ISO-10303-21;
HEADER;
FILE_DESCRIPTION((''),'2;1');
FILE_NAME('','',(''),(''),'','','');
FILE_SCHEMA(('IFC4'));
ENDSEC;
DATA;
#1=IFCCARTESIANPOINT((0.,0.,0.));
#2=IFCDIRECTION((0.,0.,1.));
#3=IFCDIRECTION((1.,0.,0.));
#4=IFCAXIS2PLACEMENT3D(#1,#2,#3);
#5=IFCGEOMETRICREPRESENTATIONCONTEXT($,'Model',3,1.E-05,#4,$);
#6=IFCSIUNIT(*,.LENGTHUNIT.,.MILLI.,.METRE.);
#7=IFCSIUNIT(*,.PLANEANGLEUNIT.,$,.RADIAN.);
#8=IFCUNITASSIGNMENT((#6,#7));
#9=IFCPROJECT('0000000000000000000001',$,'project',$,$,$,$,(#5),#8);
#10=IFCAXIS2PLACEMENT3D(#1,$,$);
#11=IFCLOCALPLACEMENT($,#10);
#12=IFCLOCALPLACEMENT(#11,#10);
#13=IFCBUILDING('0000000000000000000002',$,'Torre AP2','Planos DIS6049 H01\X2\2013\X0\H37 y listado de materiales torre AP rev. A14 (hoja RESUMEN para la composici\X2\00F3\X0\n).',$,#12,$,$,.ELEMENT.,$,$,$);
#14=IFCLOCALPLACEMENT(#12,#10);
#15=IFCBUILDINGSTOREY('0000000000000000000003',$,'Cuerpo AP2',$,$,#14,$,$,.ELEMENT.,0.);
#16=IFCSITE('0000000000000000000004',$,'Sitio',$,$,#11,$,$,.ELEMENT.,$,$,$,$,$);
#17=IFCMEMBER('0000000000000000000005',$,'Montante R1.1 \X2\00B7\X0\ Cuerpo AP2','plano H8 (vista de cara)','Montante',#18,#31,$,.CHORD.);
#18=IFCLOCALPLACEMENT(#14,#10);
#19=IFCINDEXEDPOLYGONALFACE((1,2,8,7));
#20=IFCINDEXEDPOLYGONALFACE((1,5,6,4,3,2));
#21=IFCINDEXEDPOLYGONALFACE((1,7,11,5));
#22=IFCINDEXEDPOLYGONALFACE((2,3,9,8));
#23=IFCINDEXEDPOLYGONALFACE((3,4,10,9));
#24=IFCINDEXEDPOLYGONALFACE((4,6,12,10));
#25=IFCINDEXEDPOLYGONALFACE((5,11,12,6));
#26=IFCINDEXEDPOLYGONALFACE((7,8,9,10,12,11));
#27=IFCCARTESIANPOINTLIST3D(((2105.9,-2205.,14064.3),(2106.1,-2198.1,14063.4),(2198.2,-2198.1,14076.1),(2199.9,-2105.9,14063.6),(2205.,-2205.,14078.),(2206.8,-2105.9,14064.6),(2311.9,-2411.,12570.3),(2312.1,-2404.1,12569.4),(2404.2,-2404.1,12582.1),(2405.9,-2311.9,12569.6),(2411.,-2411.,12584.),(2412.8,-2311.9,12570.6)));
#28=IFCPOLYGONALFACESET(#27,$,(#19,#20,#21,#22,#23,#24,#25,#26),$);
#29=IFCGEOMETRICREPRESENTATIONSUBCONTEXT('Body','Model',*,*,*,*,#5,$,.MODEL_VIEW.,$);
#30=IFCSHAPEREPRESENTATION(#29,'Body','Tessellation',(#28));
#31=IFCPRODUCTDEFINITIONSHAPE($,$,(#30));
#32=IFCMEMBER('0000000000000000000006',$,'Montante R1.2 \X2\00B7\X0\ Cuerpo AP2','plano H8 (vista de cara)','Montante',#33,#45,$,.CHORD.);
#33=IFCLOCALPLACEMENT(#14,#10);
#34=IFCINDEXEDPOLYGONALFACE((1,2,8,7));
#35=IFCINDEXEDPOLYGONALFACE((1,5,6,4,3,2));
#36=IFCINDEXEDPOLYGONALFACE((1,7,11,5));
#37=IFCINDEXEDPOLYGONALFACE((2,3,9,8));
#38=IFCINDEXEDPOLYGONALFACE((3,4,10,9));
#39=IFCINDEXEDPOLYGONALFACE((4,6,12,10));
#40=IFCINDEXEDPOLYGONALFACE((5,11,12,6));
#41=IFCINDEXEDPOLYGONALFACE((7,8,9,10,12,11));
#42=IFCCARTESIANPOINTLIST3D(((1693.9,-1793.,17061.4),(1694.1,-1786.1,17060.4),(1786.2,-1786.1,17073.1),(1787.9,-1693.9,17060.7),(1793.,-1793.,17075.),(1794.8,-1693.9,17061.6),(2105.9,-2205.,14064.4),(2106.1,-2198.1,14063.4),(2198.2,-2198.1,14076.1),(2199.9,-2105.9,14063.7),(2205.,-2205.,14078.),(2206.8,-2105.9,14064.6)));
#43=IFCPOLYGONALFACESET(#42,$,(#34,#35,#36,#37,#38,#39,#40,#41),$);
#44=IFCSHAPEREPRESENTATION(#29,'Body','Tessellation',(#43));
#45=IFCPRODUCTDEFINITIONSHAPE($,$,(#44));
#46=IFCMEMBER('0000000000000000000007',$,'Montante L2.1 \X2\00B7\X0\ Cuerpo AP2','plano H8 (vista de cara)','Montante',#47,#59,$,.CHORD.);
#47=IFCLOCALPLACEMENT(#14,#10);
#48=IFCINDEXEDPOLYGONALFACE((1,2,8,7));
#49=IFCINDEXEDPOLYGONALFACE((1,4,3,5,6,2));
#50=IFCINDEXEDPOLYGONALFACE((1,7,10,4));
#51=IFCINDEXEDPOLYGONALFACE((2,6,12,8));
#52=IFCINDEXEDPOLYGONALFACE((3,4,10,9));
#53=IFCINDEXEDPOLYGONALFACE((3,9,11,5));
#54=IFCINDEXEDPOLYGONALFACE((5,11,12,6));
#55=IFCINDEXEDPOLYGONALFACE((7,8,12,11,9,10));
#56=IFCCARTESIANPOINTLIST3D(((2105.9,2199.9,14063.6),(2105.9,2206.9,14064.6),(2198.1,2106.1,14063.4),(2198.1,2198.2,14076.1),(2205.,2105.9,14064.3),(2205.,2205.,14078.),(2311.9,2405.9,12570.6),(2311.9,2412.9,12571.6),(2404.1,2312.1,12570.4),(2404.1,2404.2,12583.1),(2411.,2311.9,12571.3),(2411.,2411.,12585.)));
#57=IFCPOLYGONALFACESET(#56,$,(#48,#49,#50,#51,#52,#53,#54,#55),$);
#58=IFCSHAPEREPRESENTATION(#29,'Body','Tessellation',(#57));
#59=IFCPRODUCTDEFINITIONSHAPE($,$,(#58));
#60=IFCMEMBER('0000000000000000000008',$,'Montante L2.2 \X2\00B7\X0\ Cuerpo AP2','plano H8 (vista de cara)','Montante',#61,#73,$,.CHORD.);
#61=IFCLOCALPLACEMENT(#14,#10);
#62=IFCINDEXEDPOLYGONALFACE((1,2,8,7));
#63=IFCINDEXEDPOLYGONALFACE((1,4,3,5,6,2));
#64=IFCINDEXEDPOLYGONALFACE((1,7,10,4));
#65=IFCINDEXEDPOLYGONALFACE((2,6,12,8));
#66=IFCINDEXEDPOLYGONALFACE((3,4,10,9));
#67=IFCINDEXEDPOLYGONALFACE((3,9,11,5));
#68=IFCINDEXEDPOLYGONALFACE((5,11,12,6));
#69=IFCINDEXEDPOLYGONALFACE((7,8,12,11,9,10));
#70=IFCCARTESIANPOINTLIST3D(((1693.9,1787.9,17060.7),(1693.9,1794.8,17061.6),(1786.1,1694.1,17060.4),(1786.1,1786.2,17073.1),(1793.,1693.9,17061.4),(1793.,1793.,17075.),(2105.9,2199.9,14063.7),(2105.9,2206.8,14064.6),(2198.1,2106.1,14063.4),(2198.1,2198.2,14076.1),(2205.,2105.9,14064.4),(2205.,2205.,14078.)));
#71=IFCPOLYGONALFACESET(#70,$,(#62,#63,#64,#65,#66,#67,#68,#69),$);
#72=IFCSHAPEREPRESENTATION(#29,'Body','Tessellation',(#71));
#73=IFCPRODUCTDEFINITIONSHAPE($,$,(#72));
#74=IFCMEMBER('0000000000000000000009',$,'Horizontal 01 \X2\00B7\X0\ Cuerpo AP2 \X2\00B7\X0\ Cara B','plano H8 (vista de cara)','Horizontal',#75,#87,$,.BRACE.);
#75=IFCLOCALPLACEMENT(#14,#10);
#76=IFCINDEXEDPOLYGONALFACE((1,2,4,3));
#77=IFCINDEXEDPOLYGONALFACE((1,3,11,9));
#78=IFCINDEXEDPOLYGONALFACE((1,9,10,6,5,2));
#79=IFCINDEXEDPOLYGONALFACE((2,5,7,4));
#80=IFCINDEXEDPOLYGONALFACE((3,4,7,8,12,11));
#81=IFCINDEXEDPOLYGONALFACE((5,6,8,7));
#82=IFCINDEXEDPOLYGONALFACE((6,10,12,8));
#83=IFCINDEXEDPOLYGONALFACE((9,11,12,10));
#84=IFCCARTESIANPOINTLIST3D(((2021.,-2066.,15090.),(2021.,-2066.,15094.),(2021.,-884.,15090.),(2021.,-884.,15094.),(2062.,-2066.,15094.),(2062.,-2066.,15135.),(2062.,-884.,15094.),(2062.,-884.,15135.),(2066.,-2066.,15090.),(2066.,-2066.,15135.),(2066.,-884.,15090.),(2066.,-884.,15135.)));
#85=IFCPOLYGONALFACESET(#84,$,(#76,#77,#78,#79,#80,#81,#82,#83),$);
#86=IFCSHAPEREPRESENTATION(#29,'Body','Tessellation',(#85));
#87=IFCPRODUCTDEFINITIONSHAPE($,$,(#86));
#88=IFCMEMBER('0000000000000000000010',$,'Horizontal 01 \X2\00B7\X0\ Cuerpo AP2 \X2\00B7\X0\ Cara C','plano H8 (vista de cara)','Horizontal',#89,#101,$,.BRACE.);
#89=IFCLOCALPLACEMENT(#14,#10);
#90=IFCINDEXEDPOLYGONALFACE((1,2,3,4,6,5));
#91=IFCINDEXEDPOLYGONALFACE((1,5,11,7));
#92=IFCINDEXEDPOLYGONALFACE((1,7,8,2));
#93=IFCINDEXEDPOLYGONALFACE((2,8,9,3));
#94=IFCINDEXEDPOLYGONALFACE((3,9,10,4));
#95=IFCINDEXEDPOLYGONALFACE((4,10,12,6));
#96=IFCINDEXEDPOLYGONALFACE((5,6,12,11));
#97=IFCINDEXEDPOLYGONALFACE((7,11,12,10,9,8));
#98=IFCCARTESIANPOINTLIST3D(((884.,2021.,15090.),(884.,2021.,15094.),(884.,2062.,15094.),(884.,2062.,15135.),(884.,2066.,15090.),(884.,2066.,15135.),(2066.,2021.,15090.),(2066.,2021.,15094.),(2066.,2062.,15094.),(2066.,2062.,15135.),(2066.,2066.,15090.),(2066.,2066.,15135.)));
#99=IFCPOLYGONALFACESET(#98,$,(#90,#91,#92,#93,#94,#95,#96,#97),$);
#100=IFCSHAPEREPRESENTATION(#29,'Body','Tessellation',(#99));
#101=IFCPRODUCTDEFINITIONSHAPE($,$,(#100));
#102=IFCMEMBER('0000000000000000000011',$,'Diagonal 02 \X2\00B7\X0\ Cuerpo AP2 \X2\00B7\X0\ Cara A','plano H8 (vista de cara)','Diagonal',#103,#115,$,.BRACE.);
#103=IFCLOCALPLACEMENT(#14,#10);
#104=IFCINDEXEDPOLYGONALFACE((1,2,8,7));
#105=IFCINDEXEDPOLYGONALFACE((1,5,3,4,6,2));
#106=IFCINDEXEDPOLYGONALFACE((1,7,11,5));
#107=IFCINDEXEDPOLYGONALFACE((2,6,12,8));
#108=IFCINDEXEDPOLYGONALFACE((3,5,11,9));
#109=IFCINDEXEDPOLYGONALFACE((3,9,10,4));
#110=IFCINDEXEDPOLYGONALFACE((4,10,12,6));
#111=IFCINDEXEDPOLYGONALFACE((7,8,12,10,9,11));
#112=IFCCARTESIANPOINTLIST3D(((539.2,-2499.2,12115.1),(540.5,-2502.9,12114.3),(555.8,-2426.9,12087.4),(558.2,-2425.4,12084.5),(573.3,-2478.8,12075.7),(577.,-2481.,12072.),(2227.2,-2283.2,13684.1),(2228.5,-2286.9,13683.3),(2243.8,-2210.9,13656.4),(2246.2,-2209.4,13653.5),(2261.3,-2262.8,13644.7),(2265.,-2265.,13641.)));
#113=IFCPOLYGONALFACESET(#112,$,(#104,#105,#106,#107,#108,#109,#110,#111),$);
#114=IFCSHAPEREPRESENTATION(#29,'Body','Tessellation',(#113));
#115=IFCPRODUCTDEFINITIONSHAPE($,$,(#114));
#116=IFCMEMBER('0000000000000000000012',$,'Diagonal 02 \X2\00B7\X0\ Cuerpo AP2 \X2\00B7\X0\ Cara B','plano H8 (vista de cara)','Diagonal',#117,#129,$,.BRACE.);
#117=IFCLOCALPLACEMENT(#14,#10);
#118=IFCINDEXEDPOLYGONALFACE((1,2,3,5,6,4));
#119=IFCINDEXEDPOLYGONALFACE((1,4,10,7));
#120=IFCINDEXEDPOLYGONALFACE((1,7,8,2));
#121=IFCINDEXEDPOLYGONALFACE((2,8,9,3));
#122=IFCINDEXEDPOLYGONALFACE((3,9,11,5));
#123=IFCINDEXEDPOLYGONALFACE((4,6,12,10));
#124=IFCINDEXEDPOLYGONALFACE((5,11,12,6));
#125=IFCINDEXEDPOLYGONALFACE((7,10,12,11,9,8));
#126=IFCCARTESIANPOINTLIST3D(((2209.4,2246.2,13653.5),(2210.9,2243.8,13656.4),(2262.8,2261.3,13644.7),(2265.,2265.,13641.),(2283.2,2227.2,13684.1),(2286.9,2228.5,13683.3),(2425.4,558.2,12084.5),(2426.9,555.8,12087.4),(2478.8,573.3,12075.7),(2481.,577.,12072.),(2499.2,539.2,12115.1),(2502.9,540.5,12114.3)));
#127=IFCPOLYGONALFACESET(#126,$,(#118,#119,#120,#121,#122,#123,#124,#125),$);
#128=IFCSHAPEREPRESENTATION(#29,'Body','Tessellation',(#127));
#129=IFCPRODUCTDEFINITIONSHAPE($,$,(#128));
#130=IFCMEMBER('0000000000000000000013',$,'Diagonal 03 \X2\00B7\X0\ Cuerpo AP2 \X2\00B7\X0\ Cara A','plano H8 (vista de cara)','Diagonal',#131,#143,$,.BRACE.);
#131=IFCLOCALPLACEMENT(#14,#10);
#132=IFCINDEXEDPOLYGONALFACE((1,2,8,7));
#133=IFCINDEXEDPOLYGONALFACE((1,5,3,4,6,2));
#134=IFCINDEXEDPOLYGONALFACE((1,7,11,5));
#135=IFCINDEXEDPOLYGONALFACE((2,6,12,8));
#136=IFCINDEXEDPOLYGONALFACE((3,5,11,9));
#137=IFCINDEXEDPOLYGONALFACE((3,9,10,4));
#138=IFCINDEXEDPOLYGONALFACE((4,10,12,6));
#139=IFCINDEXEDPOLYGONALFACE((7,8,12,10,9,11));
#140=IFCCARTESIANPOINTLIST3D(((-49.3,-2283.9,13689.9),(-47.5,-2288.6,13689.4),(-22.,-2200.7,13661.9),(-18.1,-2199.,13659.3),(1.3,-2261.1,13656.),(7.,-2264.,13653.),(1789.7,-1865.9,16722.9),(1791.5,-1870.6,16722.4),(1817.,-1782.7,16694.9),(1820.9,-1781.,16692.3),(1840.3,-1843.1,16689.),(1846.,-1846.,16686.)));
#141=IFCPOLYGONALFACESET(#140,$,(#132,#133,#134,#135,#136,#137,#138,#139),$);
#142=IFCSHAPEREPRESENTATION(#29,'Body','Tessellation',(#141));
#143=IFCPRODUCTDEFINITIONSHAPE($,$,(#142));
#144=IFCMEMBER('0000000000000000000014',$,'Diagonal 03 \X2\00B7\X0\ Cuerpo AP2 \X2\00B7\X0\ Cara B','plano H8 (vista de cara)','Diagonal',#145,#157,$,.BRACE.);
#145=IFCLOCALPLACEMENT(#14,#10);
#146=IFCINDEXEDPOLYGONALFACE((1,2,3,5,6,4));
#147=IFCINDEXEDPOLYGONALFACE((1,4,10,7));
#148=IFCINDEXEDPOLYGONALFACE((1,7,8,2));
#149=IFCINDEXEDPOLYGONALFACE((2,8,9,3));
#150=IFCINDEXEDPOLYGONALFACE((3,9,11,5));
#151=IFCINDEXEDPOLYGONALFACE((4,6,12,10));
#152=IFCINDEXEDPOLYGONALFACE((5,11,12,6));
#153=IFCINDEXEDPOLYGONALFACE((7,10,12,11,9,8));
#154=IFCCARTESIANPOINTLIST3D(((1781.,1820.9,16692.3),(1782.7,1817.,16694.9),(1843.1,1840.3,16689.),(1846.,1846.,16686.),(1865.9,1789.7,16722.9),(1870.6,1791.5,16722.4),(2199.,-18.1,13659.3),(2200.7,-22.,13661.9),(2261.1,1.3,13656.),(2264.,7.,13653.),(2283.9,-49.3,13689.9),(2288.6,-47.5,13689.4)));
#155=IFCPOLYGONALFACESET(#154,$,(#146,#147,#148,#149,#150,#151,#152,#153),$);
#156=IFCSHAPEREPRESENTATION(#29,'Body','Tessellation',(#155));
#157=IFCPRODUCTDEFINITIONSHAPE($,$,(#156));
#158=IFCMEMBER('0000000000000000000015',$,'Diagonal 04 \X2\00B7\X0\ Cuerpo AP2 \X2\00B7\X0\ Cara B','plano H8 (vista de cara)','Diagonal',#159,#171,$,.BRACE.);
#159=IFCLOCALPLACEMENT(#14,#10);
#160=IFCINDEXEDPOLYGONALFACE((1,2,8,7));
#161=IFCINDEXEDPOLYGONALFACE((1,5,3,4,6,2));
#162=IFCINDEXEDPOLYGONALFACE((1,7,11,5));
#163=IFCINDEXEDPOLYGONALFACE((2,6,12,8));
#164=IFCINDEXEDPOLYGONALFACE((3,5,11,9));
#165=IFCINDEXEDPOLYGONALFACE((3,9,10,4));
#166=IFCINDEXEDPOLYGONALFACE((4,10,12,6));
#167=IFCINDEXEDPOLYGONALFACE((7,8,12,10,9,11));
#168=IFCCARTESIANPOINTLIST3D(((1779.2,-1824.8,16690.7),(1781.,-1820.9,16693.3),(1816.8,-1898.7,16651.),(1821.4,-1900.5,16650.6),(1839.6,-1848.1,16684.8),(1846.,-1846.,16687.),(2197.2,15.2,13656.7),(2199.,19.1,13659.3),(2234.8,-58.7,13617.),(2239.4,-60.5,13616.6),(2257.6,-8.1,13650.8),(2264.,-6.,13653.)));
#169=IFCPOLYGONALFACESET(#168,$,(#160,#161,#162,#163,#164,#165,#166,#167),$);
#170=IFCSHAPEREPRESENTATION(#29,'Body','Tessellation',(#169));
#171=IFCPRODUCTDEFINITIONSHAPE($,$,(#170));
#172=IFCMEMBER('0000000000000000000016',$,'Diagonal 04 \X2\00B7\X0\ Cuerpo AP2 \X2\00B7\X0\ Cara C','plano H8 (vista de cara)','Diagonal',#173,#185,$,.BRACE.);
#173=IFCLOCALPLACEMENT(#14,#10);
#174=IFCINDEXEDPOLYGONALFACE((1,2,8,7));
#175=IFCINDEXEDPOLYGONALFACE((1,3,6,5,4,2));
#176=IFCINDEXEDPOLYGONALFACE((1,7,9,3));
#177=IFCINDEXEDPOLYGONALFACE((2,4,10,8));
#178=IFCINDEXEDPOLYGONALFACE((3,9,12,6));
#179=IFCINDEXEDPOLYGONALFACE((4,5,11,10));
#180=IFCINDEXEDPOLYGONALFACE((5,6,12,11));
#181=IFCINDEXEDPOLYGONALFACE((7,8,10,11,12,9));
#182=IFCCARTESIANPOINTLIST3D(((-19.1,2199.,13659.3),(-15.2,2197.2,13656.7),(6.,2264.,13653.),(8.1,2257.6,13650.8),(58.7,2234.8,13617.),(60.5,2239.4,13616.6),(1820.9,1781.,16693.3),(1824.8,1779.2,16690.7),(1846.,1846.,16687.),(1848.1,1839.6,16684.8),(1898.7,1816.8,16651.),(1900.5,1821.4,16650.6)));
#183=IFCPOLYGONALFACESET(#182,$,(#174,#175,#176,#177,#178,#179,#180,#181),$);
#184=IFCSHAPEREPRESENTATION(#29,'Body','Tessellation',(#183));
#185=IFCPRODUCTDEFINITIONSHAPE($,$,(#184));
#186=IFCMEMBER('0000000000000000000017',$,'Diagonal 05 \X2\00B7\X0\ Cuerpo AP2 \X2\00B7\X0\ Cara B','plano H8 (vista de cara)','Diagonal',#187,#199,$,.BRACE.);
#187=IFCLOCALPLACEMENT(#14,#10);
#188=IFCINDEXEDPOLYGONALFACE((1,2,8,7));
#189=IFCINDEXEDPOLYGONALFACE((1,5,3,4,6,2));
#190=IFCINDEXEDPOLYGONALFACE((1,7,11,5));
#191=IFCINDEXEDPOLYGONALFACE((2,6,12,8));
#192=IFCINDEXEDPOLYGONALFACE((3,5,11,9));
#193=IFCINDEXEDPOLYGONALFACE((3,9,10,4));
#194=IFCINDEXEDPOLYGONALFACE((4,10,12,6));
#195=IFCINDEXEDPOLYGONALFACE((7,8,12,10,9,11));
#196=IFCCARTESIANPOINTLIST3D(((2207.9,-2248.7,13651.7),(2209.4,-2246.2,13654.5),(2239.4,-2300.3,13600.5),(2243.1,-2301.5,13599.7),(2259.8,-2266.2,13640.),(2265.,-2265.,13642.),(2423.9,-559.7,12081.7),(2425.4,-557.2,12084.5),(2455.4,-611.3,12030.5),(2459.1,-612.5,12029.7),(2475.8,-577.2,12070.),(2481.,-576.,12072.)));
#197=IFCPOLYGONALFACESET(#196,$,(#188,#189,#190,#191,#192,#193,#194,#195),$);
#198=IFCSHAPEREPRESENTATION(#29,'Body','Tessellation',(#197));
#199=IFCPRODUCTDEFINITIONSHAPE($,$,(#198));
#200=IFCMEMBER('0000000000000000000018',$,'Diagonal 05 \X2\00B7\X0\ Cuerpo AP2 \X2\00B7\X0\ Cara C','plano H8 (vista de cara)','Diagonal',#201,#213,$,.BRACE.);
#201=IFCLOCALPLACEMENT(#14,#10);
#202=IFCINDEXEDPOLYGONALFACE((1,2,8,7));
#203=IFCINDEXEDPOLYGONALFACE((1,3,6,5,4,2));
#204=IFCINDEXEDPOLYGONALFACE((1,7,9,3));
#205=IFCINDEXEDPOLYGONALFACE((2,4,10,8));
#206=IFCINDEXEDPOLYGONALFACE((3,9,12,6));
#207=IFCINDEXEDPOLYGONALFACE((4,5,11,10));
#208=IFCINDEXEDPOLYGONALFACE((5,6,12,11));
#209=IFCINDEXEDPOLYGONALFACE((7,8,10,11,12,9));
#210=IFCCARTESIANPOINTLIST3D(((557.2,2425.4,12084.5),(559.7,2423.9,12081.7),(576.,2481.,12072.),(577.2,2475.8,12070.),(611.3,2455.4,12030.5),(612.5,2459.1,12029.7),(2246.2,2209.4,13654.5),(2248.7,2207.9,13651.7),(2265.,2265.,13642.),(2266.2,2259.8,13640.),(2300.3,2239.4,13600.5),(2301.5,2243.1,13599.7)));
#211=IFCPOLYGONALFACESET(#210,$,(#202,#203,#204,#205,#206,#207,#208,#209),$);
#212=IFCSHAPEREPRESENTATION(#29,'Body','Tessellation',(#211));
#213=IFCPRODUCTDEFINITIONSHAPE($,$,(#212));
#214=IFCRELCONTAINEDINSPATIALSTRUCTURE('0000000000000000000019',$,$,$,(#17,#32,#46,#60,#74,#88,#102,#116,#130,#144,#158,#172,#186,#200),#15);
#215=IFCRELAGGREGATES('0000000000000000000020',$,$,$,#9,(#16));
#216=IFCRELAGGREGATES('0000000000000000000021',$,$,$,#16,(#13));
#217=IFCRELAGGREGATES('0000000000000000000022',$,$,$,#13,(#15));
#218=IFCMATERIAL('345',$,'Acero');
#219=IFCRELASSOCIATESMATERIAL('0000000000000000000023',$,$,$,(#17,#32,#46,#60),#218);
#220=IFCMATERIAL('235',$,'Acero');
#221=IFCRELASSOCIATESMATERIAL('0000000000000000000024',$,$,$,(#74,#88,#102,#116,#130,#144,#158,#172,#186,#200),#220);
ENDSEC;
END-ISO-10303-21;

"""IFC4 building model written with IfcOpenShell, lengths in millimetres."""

from ifc_helpers import new_model, si_unit, frame, frame_2d, origin, origin_with_axes, place, context, subcontext, project, spatial, l_section, extrude, material, element, save


model = new_model("IFC4")

# Units and contexts
model_context = context("Model", 3, precision=1e-05, world=origin_with_axes())
body_context = subcontext(model_context, "Body", "Model", "MODEL_VIEW")
ifc_project = project(units=[si_unit("LENGTHUNIT", "METRE", prefix="MILLI"), si_unit("PLANEANGLEUNIT", "RADIAN")], contexts=[model_context])

# Site, building, storey
site_placement = place(None, origin())
site = spatial("IfcSite", under=ifc_project, at=site_placement, Name="Sitio", CompositionType="ELEMENT")
building_placement = place(site_placement, origin())
building = spatial("IfcBuilding", under=site, at=building_placement, Name="Torre AP2", Description="Planos DIS6049 H01–H37 y listado de materiales torre AP rev. A14 (hoja RESUMEN para la composición).", CompositionType="ELEMENT")
storey_placement = place(building_placement, origin())
storey = spatial("IfcBuildingStorey", under=building, at=storey_placement, Name="Cuerpo AP2", CompositionType="ELEMENT", Elevation=0.0)

# Members
ifc_material_1 = material(Name="345", Category="Acero")
member_1_placement = place(storey_placement, frame((2411.0, -2411.0, 12584.0), z_axis=(-0.135336, 0.135336, 0.981513), x_axis=(0.018486, 0.9908, -0.134067)))
element("IfcMember", 1, at=member_1_placement, inside=storey, material=ifc_material_1, Name="Montante R1.1 · Cuerpo AP2", Description="plano H8 (vista de cara)", ObjectType="Montante", PredefinedType="CHORD", context=body_context, shape_type="SweptSolid", body=[
    extrude(l_section(Depth=100.0, Width=100.0, Thickness=7.0, at=frame_2d((50.0, 50.0))), None, (0.0, 0.0, 1.0), 1522.1),
])
member_2_placement = place(storey_placement, frame((2205.0, -2205.0, 14078.0), z_axis=(-0.134944, 0.134944, 0.981621), x_axis=(0.018378, 0.990853, -0.133687)))
element("IfcMember", 2, at=member_2_placement, inside=storey, material=ifc_material_1, Name="Montante R1.2 · Cuerpo AP2", Description="plano H8 (vista de cara)", ObjectType="Montante", PredefinedType="CHORD", context=body_context, shape_type="SweptSolid", body=[
    extrude(l_section(Depth=100.0, Width=100.0, Thickness=7.0, at=frame_2d((50.0, 50.0))), None, (0.0, 0.0, 1.0), 3053.1),
])
member_3_placement = place(storey_placement, frame((2411.0, 2411.0, 12585.0), z_axis=(-0.135423, -0.135423, 0.981489), x_axis=(-0.990788, 0.01851, -0.134152)))
element("IfcMember", 3, at=member_3_placement, inside=storey, material=ifc_material_1, Name="Montante L2.1 · Cuerpo AP2", Description="plano H8 (vista de cara)", ObjectType="Montante", PredefinedType="CHORD", context=body_context, shape_type="SweptSolid", body=[
    extrude(l_section(Depth=100.0, Width=100.0, Thickness=7.0, at=frame_2d((50.0, 50.0))), None, (0.0, 0.0, 1.0), 1521.2),
])
member_4_placement = place(storey_placement, frame((2205.0, 2205.0, 14078.0), z_axis=(-0.134944, -0.134944, 0.981621), x_axis=(-0.990853, 0.018378, -0.133687)))
element("IfcMember", 4, at=member_4_placement, inside=storey, material=ifc_material_1, Name="Montante L2.2 · Cuerpo AP2", Description="plano H8 (vista de cara)", ObjectType="Montante", PredefinedType="CHORD", context=body_context, shape_type="SweptSolid", body=[
    extrude(l_section(Depth=100.0, Width=100.0, Thickness=7.0, at=frame_2d((50.0, 50.0))), None, (0.0, 0.0, 1.0), 3053.1),
])
ifc_material_2 = material(Name="235", Category="Acero")
for number, where, z_axis, x_axis, name in (
    (5, (2066.0, -2066.0, 15090.0), (0.0, 1.0, 0.0), (-1.0, 0.0, 0.0), "Horizontal 01 · Cuerpo AP2 · Cara B"),
    (6, (2066.0, 2066.0, 15090.0), (-1.0, 0.0, 0.0), (0.0, -1.0, 0.0), "Horizontal 01 · Cuerpo AP2 · Cara C"),
):
    element("IfcMember", number, at=place(storey_placement, frame(where, z_axis=z_axis, x_axis=x_axis)), inside=storey, material=ifc_material_2, Name=name, Description="plano H8 (vista de cara)", ObjectType="Horizontal", PredefinedType="BRACE", context=body_context, shape_type="SweptSolid", body=[
        extrude(l_section(Depth=45.0, Width=45.0, Thickness=4.0, at=frame_2d((22.5, 22.5))), None, (0.0, 0.0, 1.0), 1182.0),
    ])
for number, where, z_axis, x_axis, name in (
    (7, (577.0, -2481.0, 12072.0), (0.729257, 0.093317, 0.677846), (-0.312796, 0.926549, 0.208964), "Diagonal 02 · Cuerpo AP2 · Cara A"),
    (8, (2481.0, 577.0, 12072.0), (-0.093317, 0.729257, 0.677846), (-0.926549, -0.312796, 0.208964), "Diagonal 02 · Cuerpo AP2 · Cara B"),
):
    element("IfcMember", number, at=place(storey_placement, frame(where, z_axis=z_axis, x_axis=x_axis)), inside=storey, material=ifc_material_2, Name=name, Description="plano H8 (vista de cara)", ObjectType="Diagonal", PredefinedType="BRACE", context=body_context, shape_type="SweptSolid", body=[
        extrude(l_section(Depth=60.0, Width=60.0, Thickness=4.0, at=frame_2d((30.0, 30.0))), None, (0.0, 0.0, 1.0), 2314.7),
    ])
for number, where, z_axis, x_axis, name in (
    (9, (7.0, -2264.0, 13653.0), (0.514907, 0.117037, 0.849219), (-0.358959, 0.929042, 0.08961), "Diagonal 03 · Cuerpo AP2 · Cara A"),
    (10, (2264.0, 7.0, 13653.0), (-0.117037, 0.514907, 0.849219), (-0.929042, -0.358959, 0.08961), "Diagonal 03 · Cuerpo AP2 · Cara B"),
):
    element("IfcMember", number, at=place(storey_placement, frame(where, z_axis=z_axis, x_axis=x_axis)), inside=storey, material=ifc_material_2, Name=name, Description="plano H8 (vista de cara)", ObjectType="Diagonal", PredefinedType="BRACE", context=body_context, shape_type="SweptSolid", body=[
        extrude(l_section(Depth=70.0, Width=70.0, Thickness=5.0, at=frame_2d((35.0, 35.0))), None, (0.0, 0.0, 1.0), 3571.5),
    ])
for number, where, z_axis, x_axis, name in (
    (11, (2264.0, -6.0, 13653.0), (-0.116992, -0.514991, 0.849175), (-0.929114, 0.358779, 0.089579), "Diagonal 04 · Cuerpo AP2 · Cara B"),
    (12, (6.0, 2264.0, 13653.0), (0.514991, -0.116992, 0.849175), (-0.358779, -0.929114, 0.089579), "Diagonal 04 · Cuerpo AP2 · Cara C"),
):
    element("IfcMember", number, at=place(storey_placement, frame(where, z_axis=z_axis, x_axis=x_axis)), inside=storey, material=ifc_material_2, Name=name, Description="plano H8 (vista de cara)", ObjectType="Diagonal", PredefinedType="BRACE", context=body_context, shape_type="SweptSolid", body=[
        extrude(l_section(Depth=70.0, Width=70.0, Thickness=5.0, at=frame_2d((35.0, 35.0))), None, (0.0, 0.0, 1.0), 3572.9),
    ])
for number, where, z_axis, x_axis, name in (
    (13, (2481.0, -576.0, 12072.0), (-0.093261, -0.729246, 0.677866), (-0.92659, 0.312701, 0.208923), "Diagonal 05 · Cuerpo AP2 · Cara B"),
    (14, (576.0, 2481.0, 12072.0), (0.729246, -0.093261, 0.677866), (-0.312701, -0.92659, 0.208923), "Diagonal 05 · Cuerpo AP2 · Cara C"),
):
    element("IfcMember", number, at=place(storey_placement, frame(where, z_axis=z_axis, x_axis=x_axis)), inside=storey, material=ifc_material_2, Name=name, Description="plano H8 (vista de cara)", ObjectType="Diagonal", PredefinedType="BRACE", context=body_context, shape_type="SweptSolid", body=[
        extrude(l_section(Depth=60.0, Width=60.0, Thickness=4.0, at=frame_2d((30.0, 30.0))), None, (0.0, 0.0, 1.0), 2316.1),
    ])

save(model, "model.ifc")
